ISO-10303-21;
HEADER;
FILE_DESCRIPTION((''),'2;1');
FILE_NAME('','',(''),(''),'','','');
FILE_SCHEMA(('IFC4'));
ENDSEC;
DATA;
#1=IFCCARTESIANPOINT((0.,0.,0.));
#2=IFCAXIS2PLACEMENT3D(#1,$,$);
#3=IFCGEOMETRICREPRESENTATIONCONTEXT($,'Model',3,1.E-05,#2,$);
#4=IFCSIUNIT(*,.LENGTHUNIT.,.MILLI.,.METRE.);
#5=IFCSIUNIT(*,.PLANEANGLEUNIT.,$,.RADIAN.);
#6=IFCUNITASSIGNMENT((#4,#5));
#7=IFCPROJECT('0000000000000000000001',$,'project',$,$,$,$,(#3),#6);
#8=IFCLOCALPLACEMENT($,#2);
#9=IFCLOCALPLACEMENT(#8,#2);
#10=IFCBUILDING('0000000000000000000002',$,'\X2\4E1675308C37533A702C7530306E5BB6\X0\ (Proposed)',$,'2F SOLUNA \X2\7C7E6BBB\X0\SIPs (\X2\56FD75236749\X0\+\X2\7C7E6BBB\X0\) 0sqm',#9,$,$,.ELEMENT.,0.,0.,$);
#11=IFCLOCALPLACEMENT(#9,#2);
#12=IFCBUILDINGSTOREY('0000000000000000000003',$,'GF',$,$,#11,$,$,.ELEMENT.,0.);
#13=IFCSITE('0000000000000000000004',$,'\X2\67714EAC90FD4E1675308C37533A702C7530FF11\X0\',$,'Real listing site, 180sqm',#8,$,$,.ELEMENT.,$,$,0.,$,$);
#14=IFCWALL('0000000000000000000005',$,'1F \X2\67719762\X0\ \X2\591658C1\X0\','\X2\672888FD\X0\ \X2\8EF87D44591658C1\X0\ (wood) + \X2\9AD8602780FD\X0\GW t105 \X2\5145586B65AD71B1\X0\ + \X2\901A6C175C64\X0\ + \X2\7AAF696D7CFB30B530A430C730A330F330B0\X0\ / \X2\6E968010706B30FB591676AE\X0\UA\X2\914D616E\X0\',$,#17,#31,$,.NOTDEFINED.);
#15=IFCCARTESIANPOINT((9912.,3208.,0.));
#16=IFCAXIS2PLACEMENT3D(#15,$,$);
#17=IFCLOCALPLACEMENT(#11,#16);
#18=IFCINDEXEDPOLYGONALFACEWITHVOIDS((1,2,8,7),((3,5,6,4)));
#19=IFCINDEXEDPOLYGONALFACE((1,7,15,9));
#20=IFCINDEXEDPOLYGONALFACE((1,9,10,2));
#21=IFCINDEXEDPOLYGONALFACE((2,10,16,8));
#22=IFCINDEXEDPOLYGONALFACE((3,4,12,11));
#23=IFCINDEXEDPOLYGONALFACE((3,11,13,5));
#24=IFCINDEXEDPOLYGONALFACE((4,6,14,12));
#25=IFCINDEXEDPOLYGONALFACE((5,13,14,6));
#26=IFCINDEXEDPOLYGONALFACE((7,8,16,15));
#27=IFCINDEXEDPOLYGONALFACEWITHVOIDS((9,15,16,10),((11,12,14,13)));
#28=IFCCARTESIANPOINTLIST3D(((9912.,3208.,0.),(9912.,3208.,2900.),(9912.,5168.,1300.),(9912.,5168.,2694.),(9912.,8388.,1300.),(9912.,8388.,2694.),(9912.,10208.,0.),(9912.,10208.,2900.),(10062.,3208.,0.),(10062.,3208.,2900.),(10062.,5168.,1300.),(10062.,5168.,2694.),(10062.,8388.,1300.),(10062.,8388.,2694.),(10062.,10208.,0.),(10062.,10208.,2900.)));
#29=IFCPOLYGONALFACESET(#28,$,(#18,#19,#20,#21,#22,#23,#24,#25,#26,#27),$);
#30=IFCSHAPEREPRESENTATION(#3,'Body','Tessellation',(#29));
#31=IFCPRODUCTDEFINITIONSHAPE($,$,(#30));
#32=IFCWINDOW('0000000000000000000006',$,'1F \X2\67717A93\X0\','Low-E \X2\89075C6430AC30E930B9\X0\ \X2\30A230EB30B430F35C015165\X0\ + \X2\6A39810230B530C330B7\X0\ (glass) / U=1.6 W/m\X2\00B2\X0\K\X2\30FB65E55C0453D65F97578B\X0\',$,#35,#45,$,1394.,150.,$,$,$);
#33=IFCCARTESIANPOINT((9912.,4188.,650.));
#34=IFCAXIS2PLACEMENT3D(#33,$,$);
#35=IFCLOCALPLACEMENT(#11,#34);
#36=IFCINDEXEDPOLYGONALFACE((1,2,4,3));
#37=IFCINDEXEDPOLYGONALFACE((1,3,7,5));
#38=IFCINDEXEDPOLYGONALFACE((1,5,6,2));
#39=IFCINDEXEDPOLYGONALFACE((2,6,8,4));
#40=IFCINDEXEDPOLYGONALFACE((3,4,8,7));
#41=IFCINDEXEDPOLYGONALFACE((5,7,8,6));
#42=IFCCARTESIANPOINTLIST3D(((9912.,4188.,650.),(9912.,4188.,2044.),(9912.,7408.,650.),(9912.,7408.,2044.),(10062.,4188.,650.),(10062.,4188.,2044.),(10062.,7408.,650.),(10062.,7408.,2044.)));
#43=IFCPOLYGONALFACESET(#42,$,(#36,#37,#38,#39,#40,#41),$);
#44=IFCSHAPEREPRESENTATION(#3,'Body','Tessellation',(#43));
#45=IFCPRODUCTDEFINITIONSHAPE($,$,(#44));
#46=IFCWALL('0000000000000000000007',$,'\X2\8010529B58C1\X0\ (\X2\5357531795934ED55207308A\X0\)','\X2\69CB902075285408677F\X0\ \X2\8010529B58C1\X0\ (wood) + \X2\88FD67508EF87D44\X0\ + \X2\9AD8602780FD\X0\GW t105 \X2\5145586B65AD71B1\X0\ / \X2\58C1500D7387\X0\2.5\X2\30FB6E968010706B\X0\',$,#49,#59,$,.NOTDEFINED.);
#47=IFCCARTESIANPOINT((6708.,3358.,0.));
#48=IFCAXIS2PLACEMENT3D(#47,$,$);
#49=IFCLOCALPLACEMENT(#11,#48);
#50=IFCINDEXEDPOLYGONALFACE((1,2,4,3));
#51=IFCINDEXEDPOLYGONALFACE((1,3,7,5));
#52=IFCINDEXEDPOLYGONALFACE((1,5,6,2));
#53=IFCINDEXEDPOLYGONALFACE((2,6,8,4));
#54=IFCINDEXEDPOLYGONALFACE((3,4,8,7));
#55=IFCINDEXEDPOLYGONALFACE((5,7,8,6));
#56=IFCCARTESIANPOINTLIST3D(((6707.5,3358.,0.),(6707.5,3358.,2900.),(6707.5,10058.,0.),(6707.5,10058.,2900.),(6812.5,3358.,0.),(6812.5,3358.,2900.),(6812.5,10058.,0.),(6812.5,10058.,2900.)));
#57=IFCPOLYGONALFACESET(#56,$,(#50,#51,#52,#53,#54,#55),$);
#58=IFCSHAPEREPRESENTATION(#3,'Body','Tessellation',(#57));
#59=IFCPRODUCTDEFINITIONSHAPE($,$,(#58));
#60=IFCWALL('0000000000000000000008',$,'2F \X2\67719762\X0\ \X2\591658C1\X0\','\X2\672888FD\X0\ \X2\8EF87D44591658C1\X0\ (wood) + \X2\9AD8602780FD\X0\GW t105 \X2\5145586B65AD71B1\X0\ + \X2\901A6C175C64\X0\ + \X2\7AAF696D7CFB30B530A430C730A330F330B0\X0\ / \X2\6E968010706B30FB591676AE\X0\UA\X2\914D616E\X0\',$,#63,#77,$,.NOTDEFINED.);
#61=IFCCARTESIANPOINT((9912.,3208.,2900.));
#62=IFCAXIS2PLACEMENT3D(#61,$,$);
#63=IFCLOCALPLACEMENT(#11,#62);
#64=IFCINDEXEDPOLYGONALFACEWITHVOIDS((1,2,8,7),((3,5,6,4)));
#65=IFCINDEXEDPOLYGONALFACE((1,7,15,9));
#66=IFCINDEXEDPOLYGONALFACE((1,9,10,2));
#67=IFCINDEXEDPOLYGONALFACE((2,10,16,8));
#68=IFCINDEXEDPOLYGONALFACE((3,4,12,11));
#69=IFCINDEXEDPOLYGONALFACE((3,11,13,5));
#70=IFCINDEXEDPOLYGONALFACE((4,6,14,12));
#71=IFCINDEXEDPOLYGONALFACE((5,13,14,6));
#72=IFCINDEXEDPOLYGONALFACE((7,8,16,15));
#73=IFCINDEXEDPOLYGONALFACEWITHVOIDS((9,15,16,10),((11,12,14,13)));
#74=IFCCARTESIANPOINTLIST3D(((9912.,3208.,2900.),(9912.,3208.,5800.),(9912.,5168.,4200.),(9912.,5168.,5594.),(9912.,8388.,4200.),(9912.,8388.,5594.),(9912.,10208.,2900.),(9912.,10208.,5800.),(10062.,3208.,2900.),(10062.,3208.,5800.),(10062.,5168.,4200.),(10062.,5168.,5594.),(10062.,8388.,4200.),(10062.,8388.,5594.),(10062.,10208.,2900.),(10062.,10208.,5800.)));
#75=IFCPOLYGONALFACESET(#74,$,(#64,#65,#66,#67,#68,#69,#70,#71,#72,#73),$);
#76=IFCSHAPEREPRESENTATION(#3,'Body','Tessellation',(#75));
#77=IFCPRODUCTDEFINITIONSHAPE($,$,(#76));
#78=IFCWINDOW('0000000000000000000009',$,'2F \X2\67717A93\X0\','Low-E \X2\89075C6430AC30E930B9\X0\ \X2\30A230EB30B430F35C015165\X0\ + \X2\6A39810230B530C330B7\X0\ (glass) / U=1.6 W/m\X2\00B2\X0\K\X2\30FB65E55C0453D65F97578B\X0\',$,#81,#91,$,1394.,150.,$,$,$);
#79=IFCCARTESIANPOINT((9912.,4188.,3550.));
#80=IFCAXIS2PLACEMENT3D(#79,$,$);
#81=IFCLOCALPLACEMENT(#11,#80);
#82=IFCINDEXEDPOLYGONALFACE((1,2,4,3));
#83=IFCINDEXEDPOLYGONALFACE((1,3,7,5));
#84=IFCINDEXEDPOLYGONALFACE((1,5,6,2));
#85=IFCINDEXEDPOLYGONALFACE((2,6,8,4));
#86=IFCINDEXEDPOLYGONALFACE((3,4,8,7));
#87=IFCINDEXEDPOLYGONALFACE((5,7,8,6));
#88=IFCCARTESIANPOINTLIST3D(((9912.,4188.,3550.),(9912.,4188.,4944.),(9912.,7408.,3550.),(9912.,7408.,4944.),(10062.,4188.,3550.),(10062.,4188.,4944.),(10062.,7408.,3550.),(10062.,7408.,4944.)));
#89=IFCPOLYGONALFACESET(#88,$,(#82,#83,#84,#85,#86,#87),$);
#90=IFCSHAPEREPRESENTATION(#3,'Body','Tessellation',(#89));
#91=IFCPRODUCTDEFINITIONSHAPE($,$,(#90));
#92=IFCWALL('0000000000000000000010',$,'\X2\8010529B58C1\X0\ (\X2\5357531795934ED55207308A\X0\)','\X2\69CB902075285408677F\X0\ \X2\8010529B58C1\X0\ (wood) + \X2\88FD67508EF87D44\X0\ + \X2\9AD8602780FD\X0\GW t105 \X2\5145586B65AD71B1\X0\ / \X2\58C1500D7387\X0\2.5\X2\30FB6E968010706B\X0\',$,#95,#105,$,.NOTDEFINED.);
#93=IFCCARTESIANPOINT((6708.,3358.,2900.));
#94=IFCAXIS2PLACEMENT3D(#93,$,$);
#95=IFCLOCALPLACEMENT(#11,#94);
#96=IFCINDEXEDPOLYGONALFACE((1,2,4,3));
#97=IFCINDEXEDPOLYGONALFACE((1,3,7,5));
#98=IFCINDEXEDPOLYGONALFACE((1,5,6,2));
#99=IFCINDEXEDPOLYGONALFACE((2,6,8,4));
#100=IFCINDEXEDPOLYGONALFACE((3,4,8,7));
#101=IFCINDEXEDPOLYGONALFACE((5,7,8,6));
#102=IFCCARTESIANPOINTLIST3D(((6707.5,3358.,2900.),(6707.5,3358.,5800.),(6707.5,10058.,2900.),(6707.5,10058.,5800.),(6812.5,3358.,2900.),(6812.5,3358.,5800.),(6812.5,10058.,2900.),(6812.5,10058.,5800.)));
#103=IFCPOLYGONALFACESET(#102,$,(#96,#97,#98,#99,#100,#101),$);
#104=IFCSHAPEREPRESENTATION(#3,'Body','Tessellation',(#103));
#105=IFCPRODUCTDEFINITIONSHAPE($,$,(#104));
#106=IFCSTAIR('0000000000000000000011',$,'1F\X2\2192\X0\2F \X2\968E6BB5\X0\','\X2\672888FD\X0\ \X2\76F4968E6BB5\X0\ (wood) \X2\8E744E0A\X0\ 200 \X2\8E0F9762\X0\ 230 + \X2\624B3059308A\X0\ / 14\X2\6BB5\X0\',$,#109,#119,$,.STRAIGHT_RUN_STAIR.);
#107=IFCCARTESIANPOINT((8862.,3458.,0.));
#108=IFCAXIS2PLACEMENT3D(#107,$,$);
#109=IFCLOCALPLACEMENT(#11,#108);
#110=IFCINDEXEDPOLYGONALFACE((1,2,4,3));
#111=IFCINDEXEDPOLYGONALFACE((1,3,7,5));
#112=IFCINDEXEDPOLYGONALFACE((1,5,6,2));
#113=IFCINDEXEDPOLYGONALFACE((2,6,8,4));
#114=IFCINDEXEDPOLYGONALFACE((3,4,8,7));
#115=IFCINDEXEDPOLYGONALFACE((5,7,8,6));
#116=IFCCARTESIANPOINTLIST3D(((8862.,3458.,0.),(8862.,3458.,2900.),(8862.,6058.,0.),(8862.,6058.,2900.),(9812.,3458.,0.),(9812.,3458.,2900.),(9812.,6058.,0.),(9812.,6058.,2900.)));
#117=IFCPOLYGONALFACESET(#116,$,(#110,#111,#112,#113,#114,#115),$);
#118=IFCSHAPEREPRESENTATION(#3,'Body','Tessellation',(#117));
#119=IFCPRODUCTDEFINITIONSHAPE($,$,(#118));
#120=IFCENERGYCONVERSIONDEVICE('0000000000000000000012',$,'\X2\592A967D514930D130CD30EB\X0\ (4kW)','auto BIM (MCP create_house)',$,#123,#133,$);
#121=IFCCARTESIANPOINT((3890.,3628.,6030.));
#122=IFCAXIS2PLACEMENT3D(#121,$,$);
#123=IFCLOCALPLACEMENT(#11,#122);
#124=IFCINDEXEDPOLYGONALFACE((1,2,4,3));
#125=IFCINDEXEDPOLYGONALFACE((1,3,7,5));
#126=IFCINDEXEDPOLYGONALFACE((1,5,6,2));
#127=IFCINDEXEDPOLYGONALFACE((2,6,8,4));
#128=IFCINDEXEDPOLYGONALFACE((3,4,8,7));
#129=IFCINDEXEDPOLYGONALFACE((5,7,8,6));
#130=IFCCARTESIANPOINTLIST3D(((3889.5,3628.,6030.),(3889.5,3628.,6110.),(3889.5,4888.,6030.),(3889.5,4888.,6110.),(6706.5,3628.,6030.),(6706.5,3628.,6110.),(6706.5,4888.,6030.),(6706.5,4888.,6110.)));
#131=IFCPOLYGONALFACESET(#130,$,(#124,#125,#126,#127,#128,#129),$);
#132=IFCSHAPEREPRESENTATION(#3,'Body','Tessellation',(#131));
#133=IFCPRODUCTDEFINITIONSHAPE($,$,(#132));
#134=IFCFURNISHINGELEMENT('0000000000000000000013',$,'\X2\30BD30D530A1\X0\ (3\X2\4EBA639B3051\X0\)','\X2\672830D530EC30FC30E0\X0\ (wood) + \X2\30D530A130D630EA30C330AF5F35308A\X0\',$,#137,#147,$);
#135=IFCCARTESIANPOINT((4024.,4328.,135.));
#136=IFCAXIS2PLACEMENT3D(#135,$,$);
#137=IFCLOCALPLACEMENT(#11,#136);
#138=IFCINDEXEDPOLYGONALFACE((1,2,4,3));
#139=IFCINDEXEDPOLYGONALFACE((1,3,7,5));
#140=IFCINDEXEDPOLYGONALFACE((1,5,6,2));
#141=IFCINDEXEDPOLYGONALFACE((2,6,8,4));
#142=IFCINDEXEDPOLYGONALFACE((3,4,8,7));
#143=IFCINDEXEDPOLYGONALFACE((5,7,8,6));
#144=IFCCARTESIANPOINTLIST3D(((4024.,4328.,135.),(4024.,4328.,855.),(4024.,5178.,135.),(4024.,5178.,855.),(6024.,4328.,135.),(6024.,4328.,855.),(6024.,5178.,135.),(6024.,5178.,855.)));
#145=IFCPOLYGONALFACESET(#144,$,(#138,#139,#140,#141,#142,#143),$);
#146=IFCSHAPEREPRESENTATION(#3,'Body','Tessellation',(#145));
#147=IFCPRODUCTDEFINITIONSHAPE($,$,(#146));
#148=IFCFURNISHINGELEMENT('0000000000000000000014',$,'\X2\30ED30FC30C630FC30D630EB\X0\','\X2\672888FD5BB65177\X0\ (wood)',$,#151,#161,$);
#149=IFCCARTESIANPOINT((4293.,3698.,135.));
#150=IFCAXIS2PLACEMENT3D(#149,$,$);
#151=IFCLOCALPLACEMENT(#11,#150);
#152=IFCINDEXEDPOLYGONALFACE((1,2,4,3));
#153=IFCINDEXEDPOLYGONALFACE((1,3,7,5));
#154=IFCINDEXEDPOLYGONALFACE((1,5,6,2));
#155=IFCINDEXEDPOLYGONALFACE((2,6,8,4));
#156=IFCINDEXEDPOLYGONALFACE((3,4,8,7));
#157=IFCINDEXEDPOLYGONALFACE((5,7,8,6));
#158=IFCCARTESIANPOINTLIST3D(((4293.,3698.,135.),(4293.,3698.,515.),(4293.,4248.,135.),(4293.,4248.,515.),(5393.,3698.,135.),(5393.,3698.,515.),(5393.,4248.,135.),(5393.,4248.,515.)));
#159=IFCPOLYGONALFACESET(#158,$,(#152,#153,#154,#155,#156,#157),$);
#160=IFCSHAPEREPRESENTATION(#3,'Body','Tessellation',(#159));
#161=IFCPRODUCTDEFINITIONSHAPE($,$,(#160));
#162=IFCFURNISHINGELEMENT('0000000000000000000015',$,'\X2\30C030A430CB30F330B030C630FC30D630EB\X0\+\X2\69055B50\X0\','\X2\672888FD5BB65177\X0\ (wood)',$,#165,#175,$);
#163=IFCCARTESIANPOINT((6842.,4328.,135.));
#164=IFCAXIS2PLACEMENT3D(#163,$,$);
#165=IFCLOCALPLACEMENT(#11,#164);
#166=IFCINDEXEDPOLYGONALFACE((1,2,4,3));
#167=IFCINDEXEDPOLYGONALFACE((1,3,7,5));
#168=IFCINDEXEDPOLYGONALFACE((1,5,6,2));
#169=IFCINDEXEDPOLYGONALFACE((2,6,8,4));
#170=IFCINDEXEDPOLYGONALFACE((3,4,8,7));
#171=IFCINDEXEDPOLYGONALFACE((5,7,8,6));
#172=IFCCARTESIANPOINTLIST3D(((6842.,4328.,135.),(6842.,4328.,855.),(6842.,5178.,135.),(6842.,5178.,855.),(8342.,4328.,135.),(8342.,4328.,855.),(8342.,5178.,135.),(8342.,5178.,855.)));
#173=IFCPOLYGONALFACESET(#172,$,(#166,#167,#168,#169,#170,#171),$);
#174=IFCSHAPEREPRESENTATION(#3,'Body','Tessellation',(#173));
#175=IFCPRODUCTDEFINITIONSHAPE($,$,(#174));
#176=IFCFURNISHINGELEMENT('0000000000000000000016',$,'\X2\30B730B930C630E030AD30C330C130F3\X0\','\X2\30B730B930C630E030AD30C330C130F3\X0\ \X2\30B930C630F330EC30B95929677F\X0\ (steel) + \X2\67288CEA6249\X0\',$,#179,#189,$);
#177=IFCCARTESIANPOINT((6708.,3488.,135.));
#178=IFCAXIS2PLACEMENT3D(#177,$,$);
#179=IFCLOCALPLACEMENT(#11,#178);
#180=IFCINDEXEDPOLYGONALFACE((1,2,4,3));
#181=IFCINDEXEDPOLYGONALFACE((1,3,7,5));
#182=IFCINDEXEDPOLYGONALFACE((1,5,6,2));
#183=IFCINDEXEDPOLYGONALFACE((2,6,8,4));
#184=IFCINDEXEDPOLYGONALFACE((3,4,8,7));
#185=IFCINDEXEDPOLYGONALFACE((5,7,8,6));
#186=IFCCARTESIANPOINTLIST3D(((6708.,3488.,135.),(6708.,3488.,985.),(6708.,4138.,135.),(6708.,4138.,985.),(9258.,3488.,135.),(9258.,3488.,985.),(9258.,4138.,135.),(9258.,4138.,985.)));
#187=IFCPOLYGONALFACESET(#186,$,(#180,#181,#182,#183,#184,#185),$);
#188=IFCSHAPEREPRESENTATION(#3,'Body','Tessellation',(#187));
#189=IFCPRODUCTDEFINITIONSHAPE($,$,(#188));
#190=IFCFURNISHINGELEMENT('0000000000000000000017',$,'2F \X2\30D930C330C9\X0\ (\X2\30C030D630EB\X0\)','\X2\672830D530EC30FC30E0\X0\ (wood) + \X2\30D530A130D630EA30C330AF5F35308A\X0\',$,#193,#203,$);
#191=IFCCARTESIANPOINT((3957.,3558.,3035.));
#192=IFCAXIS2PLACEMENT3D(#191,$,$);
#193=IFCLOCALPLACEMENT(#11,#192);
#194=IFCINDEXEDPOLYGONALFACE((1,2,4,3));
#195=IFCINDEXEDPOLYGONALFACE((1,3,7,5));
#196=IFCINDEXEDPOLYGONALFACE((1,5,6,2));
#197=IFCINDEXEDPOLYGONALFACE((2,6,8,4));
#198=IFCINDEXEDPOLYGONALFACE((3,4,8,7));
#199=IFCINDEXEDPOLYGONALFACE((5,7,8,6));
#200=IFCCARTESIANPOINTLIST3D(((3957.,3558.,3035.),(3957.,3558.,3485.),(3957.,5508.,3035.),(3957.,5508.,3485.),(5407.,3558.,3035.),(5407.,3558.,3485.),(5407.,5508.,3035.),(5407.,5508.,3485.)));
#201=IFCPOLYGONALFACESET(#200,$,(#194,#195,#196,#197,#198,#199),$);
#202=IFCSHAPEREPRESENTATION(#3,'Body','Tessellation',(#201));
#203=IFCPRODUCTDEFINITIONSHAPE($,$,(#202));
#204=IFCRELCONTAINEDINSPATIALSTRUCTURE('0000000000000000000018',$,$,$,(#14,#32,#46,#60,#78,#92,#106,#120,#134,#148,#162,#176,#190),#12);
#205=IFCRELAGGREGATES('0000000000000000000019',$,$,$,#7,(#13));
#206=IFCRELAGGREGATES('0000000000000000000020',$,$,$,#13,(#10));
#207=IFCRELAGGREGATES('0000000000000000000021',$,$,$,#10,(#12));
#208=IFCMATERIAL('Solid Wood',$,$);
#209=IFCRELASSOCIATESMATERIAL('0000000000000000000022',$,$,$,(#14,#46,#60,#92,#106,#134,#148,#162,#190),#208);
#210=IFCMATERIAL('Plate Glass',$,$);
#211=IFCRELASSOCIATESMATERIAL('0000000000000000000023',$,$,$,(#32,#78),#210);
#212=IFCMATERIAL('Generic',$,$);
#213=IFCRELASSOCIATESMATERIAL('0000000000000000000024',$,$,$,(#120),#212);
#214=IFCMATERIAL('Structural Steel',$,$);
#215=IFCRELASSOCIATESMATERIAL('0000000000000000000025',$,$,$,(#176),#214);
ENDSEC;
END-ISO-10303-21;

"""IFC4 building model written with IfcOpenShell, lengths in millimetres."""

from ifc_helpers import new_model, si_unit, frame, frame_2d, origin, place, context, project, spatial, rectangle, extrude, material, element, fill, save


model = new_model("IFC4")

# Units and contexts
model_context = context("Model", 3, precision=1e-05, world=origin())
ifc_project = project(units=[si_unit("LENGTHUNIT", "METRE", prefix="MILLI"), si_unit("PLANEANGLEUNIT", "RADIAN")], contexts=[model_context])

# Site, building, storey
site_placement = place(None, origin())
site = spatial("IfcSite", under=ifc_project, at=site_placement, Name="東京都世田谷区瀬田１", ObjectType="Real listing site, 180sqm", CompositionType="ELEMENT", RefElevation=0.0)
building_placement = place(site_placement, origin())
building = spatial("IfcBuilding", under=site, at=building_placement, Name="世田谷区瀬田の家 (Proposed)", ObjectType="2F SOLUNA 籾殻SIPs (国産杉+籾殻) 0sqm", CompositionType="ELEMENT", ElevationOfRefHeight=0.0, ElevationOfTerrain=0.0)
storey_placement = place(building_placement, origin())
storey = spatial("IfcBuildingStorey", under=building, at=storey_placement, Name="GF", CompositionType="ELEMENT", Elevation=0.0)

# Wall, opening, window
ifc_material_1 = material(Name="Solid Wood")
wall_1_placement = place(storey_placement, frame((9912.0, 3208.0, 0.0)))
wall_1 = element("IfcWall", 1, at=wall_1_placement, inside=storey, material=ifc_material_1, Name="1F 東面 外壁", Description="木製 軸組外壁 (wood) + 高性能GW t105 充填断熱 + 通気層 + 窯業系サイディング / 準耐火・外皮UA配慮", PredefinedType="NOTDEFINED", context=model_context, shape_type="SweptSolid", body=[
    extrude(rectangle(XDim=150.0, YDim=7000.0, at=frame_2d((75.0, 3500.0))), frame((9912.0, 3208.0, 0.0)), (0.0, 0.0, 1.0), 2900.0),
])
opening_1_placement = place(storey_placement, frame((9912.0, 4188.0, 650.0)))
opening_1 = element("IfcOpeningElement", 2, at=opening_1_placement, cuts=wall_1, PredefinedType="NOTDEFINED", context=model_context, shape_type="SweptSolid", body=[
    extrude(rectangle(XDim=150.0, YDim=3220.0, at=frame_2d((75.0, 1610.0))), frame((9912.0, 4188.0, 650.0)), (0.0, 0.0, 1.0), 1394.0),
])
ifc_material_2 = material(Name="Plate Glass")
window_1_placement = place(storey_placement, frame((9912.0, 4188.0, 650.0)))
window_1 = element("IfcWindow", 3, at=window_1_placement, inside=storey, material=ifc_material_2, Name="1F 東窓", Description="Low-E 複層ガラス アルゴン封入 + 樹脂サッシ (glass) / U=1.6 W/m²K・日射取得型", OverallHeight=1394.0, OverallWidth=150.0, context=model_context, shape_type="SweptSolid", body=[
    extrude(rectangle(XDim=150.0, YDim=3220.0, at=frame_2d((75.0, 1610.0))), frame((9912.0, 4188.0, 650.0)), (0.0, 0.0, 1.0), 1394.0),
])
fill(opening_1, window_1)

# Wall
wall_2_placement = place(storey_placement, frame((6708.0, 3358.0, 0.0)))
element("IfcWall", 4, at=wall_2_placement, inside=storey, material=ifc_material_1, Name="耐力壁 (南北間仕切り)", Description="構造用合板 耐力壁 (wood) + 製材軸組 + 高性能GW t105 充填断熱 / 壁倍率2.5・準耐火", PredefinedType="NOTDEFINED", context=model_context, shape_type="SweptSolid", body=[
    extrude(rectangle(XDim=105.0, YDim=6700.0, at=frame_2d((52.0, 3350.0))), frame((6708.0, 3358.0, 0.0)), (0.0, 0.0, 1.0), 2900.0),
])

# Wall, opening, window
wall_3_placement = place(storey_placement, frame((9912.0, 3208.0, 2900.0)))
wall_3 = element("IfcWall", 5, at=wall_3_placement, inside=storey, material=ifc_material_1, Name="2F 東面 外壁", Description="木製 軸組外壁 (wood) + 高性能GW t105 充填断熱 + 通気層 + 窯業系サイディング / 準耐火・外皮UA配慮", PredefinedType="NOTDEFINED", context=model_context, shape_type="SweptSolid", body=[
    extrude(rectangle(XDim=150.0, YDim=7000.0, at=frame_2d((75.0, 3500.0))), frame((9912.0, 3208.0, 2900.0)), (0.0, 0.0, 1.0), 2900.0),
])
opening_2_placement = place(storey_placement, frame((9912.0, 4188.0, 3550.0)))
opening_2 = element("IfcOpeningElement", 6, at=opening_2_placement, cuts=wall_3, PredefinedType="NOTDEFINED", context=model_context, shape_type="SweptSolid", body=[
    extrude(rectangle(XDim=150.0, YDim=3220.0, at=frame_2d((75.0, 1610.0))), frame((9912.0, 4188.0, 3550.0)), (0.0, 0.0, 1.0), 1394.0),
])
window_2_placement = place(storey_placement, frame((9912.0, 4188.0, 3550.0)))
window_2 = element("IfcWindow", 7, at=window_2_placement, inside=storey, material=ifc_material_2, Name="2F 東窓", Description="Low-E 複層ガラス アルゴン封入 + 樹脂サッシ (glass) / U=1.6 W/m²K・日射取得型", OverallHeight=1394.0, OverallWidth=150.0, context=model_context, shape_type="SweptSolid", body=[
    extrude(rectangle(XDim=150.0, YDim=3220.0, at=frame_2d((75.0, 1610.0))), frame((9912.0, 4188.0, 3550.0)), (0.0, 0.0, 1.0), 1394.0),
])
fill(opening_2, window_2)

# Wall
wall_4_placement = place(storey_placement, frame((6708.0, 3358.0, 2900.0)))
element("IfcWall", 8, at=wall_4_placement, inside=storey, material=ifc_material_1, Name="耐力壁 (南北間仕切り)", Description="構造用合板 耐力壁 (wood) + 製材軸組 + 高性能GW t105 充填断熱 / 壁倍率2.5・準耐火", PredefinedType="NOTDEFINED", context=model_context, shape_type="SweptSolid", body=[
    extrude(rectangle(XDim=105.0, YDim=6700.0, at=frame_2d((52.0, 3350.0))), frame((6708.0, 3358.0, 2900.0)), (0.0, 0.0, 1.0), 2900.0),
])

# Stair
stair_placement = place(storey_placement, frame((8862.0, 3458.0, 0.0)))
element("IfcStair", 9, at=stair_placement, inside=storey, material=ifc_material_1, Name="1F→2F 階段", Description="木製 直階段 (wood) 蹴上 200 踏面 230 + 手すり / 14段", PredefinedType="STRAIGHT_RUN_STAIR", context=model_context, shape_type="SweptSolid", body=[
    extrude(rectangle(XDim=950.0, YDim=2600.0, at=frame_2d((475.0, 1300.0))), frame((8862.0, 3458.0, 0.0)), (0.0, 0.0, 1.0), 2900.0),
])

# Energy conversion device
ifc_material_3 = material(Name="Generic")
energy_conversion_device_placement = place(storey_placement, frame((3890.0, 3628.0, 6030.0)))
element("IfcEnergyConversionDevice", 10, at=energy_conversion_device_placement, inside=storey, material=ifc_material_3, Name="太陽光パネル (4kW)", Description="auto BIM (MCP create_house)", context=model_context, shape_type="SweptSolid", body=[
    extrude(rectangle(XDim=2817.0, YDim=1260.0, at=frame_2d((1408.0, 630.0))), frame((3890.0, 3628.0, 6030.0)), (0.0, 0.0, 1.0), 80.0),
])

# Furnishing elements
furnishing_1_placement = place(storey_placement, frame((4024.0, 4328.0, 135.0)))
element("IfcFurnishingElement", 11, at=furnishing_1_placement, inside=storey, material=ifc_material_1, Name="ソファ (3人掛け)", Description="木フレーム (wood) + ファブリック張り", context=model_context, shape_type="SweptSolid", body=[
    extrude(rectangle(XDim=2000.0, YDim=850.0, at=frame_2d((1000.0, 425.0))), frame((4024.0, 4328.0, 135.0)), (0.0, 0.0, 1.0), 720.0),
])
furnishing_2_placement = place(storey_placement, frame((4293.0, 3698.0, 135.0)))
element("IfcFurnishingElement", 12, at=furnishing_2_placement, inside=storey, material=ifc_material_1, Name="ローテーブル", Description="木製家具 (wood)", context=model_context, shape_type="SweptSolid", body=[
    extrude(rectangle(XDim=1100.0, YDim=550.0, at=frame_2d((550.0, 275.0))), frame((4293.0, 3698.0, 135.0)), (0.0, 0.0, 1.0), 380.0),
])
furnishing_3_placement = place(storey_placement, frame((6842.0, 4328.0, 135.0)))
element("IfcFurnishingElement", 13, at=furnishing_3_placement, inside=storey, material=ifc_material_1, Name="ダイニングテーブル+椅子", Description="木製家具 (wood)", context=model_context, shape_type="SweptSolid", body=[
    extrude(rectangle(XDim=1500.0, YDim=850.0, at=frame_2d((750.0, 425.0))), frame((6842.0, 4328.0, 135.0)), (0.0, 0.0, 1.0), 720.0),
])
ifc_material_4 = material(Name="Structural Steel")
furnishing_4_placement = place(storey_placement, frame((6708.0, 3488.0, 135.0)))
element("IfcFurnishingElement", 14, at=furnishing_4_placement, inside=storey, material=ifc_material_4, Name="システムキッチン", Description="システムキッチン ステンレス天板 (steel) + 木質扉", context=model_context, shape_type="SweptSolid", body=[
    extrude(rectangle(XDim=2550.0, YDim=650.0, at=frame_2d((1275.0, 325.0))), frame((6708.0, 3488.0, 135.0)), (0.0, 0.0, 1.0), 850.0),
])
furnishing_5_placement = place(storey_placement, frame((3957.0, 3558.0, 3035.0)))
element("IfcFurnishingElement", 15, at=furnishing_5_placement, inside=storey, material=ifc_material_1, Name="2F ベッド (ダブル)", Description="木フレーム (wood) + ファブリック張り", context=model_context, shape_type="SweptSolid", body=[
    extrude(rectangle(XDim=1450.0, YDim=1950.0, at=frame_2d((725.0, 975.0))), frame((3957.0, 3558.0, 3035.0)), (0.0, 0.0, 1.0), 450.0),
])

save(model, "model.ifc")
